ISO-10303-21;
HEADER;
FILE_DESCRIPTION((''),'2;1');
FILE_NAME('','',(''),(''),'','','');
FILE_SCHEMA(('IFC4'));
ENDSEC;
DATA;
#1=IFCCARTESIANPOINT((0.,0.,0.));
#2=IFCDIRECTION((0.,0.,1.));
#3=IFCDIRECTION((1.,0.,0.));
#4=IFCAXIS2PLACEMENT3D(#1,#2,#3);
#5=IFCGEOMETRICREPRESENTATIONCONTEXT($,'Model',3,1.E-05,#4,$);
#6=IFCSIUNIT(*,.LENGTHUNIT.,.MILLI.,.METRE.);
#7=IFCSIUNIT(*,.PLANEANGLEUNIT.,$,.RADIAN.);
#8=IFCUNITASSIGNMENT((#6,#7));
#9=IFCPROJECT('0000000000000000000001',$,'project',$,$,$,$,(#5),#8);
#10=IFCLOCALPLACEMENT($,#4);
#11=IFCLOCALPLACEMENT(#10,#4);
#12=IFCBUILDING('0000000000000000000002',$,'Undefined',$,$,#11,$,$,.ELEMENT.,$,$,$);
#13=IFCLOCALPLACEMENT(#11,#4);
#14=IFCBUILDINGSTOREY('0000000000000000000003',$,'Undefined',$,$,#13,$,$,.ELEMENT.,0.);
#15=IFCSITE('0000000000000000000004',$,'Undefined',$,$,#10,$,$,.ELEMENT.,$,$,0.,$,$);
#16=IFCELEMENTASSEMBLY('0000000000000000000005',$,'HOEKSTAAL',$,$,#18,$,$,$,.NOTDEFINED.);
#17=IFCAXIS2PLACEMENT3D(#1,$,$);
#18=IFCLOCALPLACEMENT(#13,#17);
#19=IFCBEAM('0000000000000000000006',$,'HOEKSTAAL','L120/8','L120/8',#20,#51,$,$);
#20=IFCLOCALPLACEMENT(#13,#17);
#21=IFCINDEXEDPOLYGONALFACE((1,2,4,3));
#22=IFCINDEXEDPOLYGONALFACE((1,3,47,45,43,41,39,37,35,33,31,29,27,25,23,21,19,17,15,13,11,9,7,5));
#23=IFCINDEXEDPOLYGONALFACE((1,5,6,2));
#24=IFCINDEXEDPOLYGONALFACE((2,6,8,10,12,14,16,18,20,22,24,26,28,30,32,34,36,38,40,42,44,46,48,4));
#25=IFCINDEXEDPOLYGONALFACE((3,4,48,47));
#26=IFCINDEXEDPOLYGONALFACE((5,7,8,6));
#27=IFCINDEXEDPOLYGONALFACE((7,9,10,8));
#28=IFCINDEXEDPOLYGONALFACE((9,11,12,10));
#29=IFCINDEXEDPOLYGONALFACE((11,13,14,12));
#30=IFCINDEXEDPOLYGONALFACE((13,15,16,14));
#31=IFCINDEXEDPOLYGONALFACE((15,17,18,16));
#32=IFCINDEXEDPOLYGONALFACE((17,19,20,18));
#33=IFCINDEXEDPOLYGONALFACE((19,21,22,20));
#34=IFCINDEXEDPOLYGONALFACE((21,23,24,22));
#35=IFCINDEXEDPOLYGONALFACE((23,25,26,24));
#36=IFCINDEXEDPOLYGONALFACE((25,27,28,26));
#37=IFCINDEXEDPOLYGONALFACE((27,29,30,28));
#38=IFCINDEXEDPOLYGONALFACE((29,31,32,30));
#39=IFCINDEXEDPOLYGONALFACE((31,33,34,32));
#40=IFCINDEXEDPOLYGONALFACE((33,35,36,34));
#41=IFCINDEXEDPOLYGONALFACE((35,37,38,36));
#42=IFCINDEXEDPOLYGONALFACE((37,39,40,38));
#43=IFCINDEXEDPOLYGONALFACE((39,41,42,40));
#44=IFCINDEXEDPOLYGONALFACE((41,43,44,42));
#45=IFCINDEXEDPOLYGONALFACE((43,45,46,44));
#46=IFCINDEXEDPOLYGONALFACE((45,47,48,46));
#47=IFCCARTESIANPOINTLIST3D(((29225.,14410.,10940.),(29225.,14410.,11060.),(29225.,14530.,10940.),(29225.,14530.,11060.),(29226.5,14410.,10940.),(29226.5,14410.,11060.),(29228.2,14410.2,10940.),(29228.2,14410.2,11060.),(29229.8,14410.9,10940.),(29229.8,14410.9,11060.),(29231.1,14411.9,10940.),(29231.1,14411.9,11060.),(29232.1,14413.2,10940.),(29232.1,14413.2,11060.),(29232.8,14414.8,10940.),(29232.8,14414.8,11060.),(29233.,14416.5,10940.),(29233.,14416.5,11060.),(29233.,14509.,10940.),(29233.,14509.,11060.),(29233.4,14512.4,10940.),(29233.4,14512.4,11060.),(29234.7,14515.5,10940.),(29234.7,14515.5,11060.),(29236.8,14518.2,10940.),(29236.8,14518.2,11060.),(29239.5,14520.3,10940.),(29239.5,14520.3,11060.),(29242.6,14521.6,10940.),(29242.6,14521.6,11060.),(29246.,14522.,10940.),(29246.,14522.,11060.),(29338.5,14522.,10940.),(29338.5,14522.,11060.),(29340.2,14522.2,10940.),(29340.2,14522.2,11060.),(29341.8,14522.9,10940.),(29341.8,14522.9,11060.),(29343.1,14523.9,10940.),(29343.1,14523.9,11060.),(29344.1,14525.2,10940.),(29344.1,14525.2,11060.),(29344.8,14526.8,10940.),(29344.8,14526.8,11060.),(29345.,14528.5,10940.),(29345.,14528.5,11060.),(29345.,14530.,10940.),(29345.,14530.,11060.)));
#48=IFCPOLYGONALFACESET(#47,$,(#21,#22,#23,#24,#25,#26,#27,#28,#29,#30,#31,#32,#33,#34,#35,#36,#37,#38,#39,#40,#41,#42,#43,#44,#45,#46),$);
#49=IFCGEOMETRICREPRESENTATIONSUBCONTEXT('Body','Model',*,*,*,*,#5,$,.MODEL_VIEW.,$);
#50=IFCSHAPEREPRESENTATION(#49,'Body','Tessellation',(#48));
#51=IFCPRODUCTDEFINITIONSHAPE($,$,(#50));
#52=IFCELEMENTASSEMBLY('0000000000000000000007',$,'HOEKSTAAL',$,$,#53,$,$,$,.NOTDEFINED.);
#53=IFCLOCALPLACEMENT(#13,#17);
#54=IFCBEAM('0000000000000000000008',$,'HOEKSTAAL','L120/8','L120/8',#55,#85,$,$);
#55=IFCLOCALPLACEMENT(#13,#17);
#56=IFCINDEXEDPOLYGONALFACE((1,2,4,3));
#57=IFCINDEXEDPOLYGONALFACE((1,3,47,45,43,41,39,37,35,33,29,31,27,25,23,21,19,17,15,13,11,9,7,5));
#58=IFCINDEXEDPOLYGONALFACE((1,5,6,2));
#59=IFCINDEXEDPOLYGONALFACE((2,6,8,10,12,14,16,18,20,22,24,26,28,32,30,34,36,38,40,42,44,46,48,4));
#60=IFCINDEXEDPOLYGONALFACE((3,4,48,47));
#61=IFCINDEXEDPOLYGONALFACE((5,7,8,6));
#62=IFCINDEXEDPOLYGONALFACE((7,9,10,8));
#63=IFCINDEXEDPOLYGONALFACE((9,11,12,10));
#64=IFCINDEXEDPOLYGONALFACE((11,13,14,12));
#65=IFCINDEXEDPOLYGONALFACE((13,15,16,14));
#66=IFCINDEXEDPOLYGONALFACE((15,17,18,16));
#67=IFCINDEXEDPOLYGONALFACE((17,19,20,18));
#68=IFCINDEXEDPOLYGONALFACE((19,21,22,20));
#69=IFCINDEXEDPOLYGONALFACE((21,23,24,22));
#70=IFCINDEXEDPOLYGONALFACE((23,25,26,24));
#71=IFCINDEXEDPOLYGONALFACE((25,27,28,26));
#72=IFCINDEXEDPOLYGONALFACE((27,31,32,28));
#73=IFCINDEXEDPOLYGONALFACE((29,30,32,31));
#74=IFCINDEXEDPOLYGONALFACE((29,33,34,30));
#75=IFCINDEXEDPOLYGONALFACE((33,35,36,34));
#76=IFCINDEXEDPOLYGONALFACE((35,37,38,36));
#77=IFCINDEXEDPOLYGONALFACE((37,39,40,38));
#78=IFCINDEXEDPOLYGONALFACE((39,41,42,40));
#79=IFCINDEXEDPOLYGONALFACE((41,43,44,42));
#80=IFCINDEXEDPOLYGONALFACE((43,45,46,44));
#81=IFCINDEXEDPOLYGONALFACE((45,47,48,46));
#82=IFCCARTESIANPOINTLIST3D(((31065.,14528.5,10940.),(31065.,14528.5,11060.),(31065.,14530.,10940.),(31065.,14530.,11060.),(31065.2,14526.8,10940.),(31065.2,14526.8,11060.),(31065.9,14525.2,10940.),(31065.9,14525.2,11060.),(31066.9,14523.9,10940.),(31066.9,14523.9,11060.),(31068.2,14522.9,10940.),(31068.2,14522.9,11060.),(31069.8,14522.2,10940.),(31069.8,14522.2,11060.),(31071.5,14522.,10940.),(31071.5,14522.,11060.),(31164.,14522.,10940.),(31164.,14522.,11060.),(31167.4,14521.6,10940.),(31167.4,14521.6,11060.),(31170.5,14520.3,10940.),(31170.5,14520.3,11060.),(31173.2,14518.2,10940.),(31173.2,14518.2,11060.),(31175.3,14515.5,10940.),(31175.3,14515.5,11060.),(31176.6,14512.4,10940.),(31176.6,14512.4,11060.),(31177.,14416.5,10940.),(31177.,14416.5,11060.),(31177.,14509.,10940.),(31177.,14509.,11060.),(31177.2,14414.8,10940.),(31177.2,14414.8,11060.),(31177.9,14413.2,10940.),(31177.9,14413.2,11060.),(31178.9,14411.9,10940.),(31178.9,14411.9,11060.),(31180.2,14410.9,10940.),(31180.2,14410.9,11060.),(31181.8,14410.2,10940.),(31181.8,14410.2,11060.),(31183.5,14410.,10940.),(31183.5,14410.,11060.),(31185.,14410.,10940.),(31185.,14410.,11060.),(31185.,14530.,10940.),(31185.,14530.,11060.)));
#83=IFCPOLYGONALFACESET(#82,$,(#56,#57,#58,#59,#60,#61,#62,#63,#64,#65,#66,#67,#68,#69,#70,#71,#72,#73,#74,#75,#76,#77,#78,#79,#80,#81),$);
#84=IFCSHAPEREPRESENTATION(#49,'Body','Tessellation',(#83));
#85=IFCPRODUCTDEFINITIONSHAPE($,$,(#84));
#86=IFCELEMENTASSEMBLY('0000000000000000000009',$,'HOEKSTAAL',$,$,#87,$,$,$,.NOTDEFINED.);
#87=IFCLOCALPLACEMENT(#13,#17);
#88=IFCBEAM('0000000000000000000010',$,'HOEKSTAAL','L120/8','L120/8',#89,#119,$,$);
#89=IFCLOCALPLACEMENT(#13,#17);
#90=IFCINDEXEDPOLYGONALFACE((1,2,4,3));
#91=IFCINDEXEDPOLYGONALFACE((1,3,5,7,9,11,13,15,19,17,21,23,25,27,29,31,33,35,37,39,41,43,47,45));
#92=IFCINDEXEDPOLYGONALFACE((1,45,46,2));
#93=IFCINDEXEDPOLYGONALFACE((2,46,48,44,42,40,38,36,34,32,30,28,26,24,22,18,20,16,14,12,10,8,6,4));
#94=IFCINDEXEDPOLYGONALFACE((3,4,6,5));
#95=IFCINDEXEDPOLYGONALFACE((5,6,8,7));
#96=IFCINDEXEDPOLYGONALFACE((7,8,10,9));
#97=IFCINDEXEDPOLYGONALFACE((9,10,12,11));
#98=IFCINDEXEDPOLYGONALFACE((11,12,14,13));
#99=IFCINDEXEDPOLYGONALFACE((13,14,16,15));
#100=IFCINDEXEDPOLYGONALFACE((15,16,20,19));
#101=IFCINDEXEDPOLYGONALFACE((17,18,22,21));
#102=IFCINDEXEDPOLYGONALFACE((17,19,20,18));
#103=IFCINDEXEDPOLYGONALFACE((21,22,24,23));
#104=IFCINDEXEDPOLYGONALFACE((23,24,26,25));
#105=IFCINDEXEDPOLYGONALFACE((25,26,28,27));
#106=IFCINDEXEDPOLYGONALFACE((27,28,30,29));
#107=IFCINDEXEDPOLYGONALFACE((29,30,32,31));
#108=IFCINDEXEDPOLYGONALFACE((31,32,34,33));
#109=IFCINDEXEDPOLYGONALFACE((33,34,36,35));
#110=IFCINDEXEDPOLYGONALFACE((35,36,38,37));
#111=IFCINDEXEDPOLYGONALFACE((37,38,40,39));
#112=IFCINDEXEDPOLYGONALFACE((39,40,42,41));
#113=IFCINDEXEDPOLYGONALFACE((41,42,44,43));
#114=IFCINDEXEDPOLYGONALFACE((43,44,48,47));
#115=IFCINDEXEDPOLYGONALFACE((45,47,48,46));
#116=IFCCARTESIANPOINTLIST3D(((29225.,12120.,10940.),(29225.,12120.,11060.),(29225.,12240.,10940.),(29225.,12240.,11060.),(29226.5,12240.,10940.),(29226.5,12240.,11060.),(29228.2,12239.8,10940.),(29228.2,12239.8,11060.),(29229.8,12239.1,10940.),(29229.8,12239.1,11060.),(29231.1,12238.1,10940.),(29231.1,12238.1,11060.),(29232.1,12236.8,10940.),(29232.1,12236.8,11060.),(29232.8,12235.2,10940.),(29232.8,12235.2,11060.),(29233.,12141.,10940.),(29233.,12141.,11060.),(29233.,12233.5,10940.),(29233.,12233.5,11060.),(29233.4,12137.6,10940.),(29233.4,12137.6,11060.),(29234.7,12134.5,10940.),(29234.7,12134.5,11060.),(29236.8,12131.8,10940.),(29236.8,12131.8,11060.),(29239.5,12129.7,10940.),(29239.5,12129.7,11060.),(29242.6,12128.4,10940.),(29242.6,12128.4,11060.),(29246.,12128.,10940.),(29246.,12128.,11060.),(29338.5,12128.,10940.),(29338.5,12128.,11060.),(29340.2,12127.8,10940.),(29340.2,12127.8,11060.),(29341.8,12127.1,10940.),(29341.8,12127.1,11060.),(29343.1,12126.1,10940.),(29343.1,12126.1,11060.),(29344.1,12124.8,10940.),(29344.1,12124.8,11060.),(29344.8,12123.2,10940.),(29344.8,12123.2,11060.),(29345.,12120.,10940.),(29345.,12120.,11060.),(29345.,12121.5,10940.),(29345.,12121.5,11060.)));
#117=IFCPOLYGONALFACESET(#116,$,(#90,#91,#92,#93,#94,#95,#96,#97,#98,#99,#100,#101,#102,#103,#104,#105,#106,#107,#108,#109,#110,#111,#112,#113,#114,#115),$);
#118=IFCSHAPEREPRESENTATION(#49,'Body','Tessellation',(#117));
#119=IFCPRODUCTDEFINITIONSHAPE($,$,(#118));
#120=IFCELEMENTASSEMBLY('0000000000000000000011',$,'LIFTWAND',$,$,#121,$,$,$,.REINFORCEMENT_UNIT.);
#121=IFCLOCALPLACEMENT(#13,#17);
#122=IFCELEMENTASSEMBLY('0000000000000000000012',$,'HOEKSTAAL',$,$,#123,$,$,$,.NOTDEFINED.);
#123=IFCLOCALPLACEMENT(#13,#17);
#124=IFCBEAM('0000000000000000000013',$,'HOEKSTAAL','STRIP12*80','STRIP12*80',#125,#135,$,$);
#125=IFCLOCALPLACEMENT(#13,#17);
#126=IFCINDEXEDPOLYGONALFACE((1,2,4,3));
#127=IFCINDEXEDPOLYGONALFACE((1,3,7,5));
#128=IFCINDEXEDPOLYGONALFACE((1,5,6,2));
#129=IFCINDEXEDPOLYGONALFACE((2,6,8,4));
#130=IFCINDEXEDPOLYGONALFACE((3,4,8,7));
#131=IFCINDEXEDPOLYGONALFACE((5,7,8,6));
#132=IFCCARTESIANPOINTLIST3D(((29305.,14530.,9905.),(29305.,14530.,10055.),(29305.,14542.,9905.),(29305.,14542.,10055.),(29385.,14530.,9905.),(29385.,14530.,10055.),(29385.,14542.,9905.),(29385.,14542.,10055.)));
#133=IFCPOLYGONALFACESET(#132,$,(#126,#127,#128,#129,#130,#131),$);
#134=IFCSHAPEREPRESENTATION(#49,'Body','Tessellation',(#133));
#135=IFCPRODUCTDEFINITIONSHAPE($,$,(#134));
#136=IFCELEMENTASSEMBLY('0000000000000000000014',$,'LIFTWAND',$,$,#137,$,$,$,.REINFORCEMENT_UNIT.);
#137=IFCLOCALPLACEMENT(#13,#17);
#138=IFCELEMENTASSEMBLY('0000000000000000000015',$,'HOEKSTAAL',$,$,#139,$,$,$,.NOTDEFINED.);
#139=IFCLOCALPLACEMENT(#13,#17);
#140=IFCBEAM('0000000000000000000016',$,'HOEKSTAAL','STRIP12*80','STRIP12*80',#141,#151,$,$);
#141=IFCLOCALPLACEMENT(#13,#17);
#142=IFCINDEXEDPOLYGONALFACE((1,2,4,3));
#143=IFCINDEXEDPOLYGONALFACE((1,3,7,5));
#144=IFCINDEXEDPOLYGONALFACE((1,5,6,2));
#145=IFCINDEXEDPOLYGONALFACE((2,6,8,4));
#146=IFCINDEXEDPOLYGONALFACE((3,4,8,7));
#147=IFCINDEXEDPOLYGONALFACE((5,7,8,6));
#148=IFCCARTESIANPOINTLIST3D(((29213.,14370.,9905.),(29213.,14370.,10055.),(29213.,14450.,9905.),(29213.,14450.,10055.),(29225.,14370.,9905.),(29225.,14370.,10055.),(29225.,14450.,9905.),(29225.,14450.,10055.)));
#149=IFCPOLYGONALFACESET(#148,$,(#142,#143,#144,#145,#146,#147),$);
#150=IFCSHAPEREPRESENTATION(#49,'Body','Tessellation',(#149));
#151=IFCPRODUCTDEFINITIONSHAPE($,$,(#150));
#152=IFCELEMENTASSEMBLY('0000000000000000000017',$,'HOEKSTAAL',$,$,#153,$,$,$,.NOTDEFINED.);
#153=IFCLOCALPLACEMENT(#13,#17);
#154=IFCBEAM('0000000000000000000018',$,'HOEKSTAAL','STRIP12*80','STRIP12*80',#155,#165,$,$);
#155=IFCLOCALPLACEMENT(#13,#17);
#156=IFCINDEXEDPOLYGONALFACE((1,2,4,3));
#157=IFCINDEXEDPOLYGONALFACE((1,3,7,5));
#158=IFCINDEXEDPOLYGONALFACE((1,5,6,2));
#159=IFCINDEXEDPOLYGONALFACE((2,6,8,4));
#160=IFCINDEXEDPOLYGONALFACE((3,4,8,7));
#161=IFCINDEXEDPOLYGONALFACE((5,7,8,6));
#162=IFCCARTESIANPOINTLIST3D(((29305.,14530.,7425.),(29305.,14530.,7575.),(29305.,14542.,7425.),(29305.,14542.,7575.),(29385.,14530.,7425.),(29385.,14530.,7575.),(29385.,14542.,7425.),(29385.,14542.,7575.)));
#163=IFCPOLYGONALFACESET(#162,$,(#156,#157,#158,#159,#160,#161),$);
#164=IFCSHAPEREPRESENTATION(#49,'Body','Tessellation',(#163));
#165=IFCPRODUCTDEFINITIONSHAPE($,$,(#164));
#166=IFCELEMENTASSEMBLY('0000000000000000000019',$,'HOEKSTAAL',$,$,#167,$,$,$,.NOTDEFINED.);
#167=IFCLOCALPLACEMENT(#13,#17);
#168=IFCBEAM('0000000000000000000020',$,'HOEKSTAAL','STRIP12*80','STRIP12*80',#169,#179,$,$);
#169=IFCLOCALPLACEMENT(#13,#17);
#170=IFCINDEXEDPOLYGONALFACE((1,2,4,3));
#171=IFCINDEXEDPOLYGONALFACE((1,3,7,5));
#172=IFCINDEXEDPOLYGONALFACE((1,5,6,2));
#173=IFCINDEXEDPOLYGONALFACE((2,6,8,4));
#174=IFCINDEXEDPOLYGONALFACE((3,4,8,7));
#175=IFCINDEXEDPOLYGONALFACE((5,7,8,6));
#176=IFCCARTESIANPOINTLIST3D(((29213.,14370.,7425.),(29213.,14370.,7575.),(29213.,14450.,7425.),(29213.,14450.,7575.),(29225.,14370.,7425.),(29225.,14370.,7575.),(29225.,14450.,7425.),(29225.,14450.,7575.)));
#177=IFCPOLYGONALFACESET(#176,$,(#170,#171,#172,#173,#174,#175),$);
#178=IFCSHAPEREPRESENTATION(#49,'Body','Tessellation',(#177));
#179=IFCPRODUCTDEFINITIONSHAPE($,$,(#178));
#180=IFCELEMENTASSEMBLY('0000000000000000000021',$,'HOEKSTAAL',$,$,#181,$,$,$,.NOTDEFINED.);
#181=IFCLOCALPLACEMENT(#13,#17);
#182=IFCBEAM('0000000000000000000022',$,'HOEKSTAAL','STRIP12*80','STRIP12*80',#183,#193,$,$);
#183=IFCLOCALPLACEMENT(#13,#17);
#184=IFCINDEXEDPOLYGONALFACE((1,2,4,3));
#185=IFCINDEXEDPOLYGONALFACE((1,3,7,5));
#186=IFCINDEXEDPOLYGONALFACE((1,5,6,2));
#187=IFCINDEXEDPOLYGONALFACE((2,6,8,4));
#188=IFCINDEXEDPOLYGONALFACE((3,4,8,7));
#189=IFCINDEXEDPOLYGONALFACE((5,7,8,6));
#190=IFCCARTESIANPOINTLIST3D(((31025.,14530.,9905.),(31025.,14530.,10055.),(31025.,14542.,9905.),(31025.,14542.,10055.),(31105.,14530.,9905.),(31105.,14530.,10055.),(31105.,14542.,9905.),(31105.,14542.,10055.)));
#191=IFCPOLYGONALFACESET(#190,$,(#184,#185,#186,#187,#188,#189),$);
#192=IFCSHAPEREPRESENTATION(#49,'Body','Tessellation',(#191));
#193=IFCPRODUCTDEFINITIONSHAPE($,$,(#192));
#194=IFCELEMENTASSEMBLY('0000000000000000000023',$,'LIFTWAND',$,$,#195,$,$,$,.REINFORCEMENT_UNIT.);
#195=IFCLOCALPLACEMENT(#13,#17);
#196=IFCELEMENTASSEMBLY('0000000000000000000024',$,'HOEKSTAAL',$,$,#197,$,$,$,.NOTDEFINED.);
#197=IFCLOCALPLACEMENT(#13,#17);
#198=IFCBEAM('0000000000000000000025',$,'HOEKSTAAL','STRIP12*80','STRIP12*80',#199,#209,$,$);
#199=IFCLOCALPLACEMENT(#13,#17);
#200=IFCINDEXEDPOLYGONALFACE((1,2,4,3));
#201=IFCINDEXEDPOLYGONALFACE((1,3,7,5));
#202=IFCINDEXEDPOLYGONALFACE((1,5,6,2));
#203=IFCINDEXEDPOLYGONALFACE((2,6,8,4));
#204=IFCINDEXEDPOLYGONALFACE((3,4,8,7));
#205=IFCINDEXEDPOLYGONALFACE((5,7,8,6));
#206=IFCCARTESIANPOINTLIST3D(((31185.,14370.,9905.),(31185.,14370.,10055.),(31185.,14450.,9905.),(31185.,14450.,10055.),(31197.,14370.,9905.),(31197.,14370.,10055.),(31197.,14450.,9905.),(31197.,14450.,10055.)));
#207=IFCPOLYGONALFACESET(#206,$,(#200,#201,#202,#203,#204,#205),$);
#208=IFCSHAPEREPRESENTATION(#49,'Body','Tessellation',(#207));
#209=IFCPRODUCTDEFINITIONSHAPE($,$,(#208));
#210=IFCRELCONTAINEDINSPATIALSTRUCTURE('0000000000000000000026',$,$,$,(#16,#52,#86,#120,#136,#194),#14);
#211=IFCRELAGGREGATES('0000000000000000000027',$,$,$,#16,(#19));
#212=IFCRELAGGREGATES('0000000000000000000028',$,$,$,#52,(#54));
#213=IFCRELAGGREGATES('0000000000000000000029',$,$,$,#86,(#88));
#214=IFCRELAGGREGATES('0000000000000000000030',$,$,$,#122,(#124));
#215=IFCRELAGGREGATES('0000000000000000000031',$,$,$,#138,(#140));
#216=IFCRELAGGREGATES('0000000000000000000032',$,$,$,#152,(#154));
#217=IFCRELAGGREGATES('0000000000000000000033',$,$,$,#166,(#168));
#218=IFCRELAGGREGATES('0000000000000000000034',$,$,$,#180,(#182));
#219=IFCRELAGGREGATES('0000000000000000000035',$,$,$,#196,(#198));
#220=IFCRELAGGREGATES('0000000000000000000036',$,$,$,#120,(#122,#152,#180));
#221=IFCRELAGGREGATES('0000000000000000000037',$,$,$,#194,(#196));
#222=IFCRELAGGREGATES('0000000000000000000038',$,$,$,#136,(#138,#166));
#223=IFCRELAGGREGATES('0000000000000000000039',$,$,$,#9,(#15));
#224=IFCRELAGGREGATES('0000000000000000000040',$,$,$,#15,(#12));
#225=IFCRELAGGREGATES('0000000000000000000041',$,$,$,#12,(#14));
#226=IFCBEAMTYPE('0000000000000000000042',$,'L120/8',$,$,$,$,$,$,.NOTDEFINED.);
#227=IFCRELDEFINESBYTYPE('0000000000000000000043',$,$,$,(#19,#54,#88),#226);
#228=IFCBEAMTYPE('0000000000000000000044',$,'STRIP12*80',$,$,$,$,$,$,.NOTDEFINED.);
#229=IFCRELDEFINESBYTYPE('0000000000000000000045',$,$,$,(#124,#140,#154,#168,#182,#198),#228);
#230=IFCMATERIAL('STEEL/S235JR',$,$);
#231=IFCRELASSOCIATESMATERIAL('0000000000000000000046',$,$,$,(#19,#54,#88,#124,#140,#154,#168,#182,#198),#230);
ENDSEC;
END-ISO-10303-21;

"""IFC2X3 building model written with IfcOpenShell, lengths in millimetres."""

from ifc_helpers import new_model, si_unit, frame, origin_with_axes, origin_2d_with_axis, place, context, subcontext, project, spatial, rectangle, l_section, extrude, material, type_object, element, aggregate, save


model = new_model("IFC2X3")

# Units and contexts
model_context = context("Model", 3, precision=1e-05, world=origin_with_axes())
body_context = subcontext(model_context, "Body", "Model", "MODEL_VIEW")
ifc_project = project(units=[si_unit("LENGTHUNIT", "METRE", prefix="MILLI"), si_unit("PLANEANGLEUNIT", "RADIAN")], contexts=[model_context])

# Site, building, storey
site_placement = place(None, origin_with_axes())
site = spatial("IfcSite", under=ifc_project, at=site_placement, Name="Undefined", CompositionType="ELEMENT", RefElevation=0.0)
building_placement = place(site_placement, origin_with_axes())
building = spatial("IfcBuilding", under=site, at=building_placement, Name="Undefined", CompositionType="ELEMENT")
storey_placement = place(building_placement, origin_with_axes())
storey = spatial("IfcBuildingStorey", under=building, at=storey_placement, Name="Undefined", CompositionType="ELEMENT", Elevation=0.0)

# Element assemblies, beams
ifc_material_1 = material(Name="STEEL/S235JR")
beam_type_1 = type_object("IfcBeamType", Name="L120/8", PredefinedType="NOTDEFINED")
assembly_1_placement = place(storey_placement, origin_with_axes())
assembly_1 = element("IfcElementAssembly", 1, at=assembly_1_placement, inside=storey, Name="HOEKSTAAL", PredefinedType="NOTDEFINED")
beam_1_placement = place(assembly_1_placement, frame((29285.0, 14470.0, 11060.0), z_axis=(1.0, 0.0, 0.0), x_axis=(0.0, 0.0, -1.0)))
beam_1 = element("IfcBeam", 2, at=beam_1_placement, type_object=beam_type_1, material=ifc_material_1, Name="HOEKSTAAL", Description="L120/8", ObjectType="L120/8", context=body_context, shape_type="SweptSolid", body=[
    extrude(l_section(Depth=120.0, Width=120.0, Thickness=8.0, FilletRadius=13.0, EdgeRadius=6.5, at=origin_2d_with_axis()), frame((120.0, 0.0, 0.0), z_axis=(-1.0, 0.0, 0.0), x_axis=(0.0, -1.0, 0.0)), (0.0, 0.0, 1.0), 120.0),
])
aggregate(assembly_1, [beam_1])
assembly_2_placement = place(storey_placement, origin_with_axes())
assembly_2 = element("IfcElementAssembly", 3, at=assembly_2_placement, inside=storey, Name="HOEKSTAAL", PredefinedType="NOTDEFINED")
beam_2_placement = place(assembly_2_placement, frame((31125.0, 14470.0, 10940.0), z_axis=(-1.0, 0.0, 0.0), x_axis=(0.0, 0.0, 1.0)))
beam_2 = element("IfcBeam", 4, at=beam_2_placement, type_object=beam_type_1, material=ifc_material_1, Name="HOEKSTAAL", Description="L120/8", ObjectType="L120/8", context=body_context, shape_type="SweptSolid", body=[
    extrude(l_section(Depth=120.0, Width=120.0, Thickness=8.0, FilletRadius=13.0, EdgeRadius=6.5, at=origin_2d_with_axis()), frame((120.0, 0.0, 0.0), z_axis=(-1.0, 0.0, 0.0), x_axis=(0.0, -1.0, 0.0)), (0.0, 0.0, 1.0), 120.0),
])
aggregate(assembly_2, [beam_2])
assembly_3_placement = place(storey_placement, origin_with_axes())
assembly_3 = element("IfcElementAssembly", 5, at=assembly_3_placement, inside=storey, Name="HOEKSTAAL", PredefinedType="NOTDEFINED")
beam_3_placement = place(assembly_3_placement, frame((29285.0, 12180.0, 10940.0), z_axis=(1.0, 0.0, 0.0), x_axis=(0.0, 0.0, 1.0)))
beam_3 = element("IfcBeam", 6, at=beam_3_placement, type_object=beam_type_1, material=ifc_material_1, Name="HOEKSTAAL", Description="L120/8", ObjectType="L120/8", context=body_context, shape_type="SweptSolid", body=[
    extrude(l_section(Depth=120.0, Width=120.0, Thickness=8.0, FilletRadius=13.0, EdgeRadius=6.5, at=origin_2d_with_axis()), frame((120.0, 0.0, 0.0), z_axis=(-1.0, 0.0, 0.0), x_axis=(0.0, -1.0, 0.0)), (0.0, 0.0, 1.0), 120.0),
])
aggregate(assembly_3, [beam_3])

# Element assemblies, beams
assembly_4_placement = place(storey_placement, origin_with_axes())
assembly_4 = element("IfcElementAssembly", 7, at=assembly_4_placement, inside=storey, Name="LIFTWAND", PredefinedType="REINFORCEMENT_UNIT")
assembly_5_placement = place(assembly_4_placement, origin_with_axes())
assembly_5 = element("IfcElementAssembly", 8, at=assembly_5_placement, Name="HOEKSTAAL", PredefinedType="NOTDEFINED")
beam_type_2 = type_object("IfcBeamType", Name="STRIP12*80", PredefinedType="NOTDEFINED")
beam_4_placement = place(assembly_5_placement, frame((29345.0, 14536.0, 10055.0), z_axis=(1.0, 0.0, 0.0), x_axis=(0.0, 0.0, -1.0)))
beam_4 = element("IfcBeam", 9, at=beam_4_placement, type_object=beam_type_2, material=ifc_material_1, Name="HOEKSTAAL", Description="STRIP12*80", ObjectType="STRIP12*80", context=body_context, shape_type="SweptSolid", body=[
    extrude(rectangle(XDim=12.0, YDim=80.0, at=origin_2d_with_axis()), frame((150.0, 0.0, 0.0), z_axis=(-1.0, 0.0, 0.0), x_axis=(0.0, -1.0, 0.0)), (0.0, 0.0, 1.0), 150.0),
])
aggregate(assembly_5, [beam_4])
assembly_6_placement = place(storey_placement, origin_with_axes())
assembly_6 = element("IfcElementAssembly", 10, at=assembly_6_placement, inside=storey, Name="LIFTWAND", PredefinedType="REINFORCEMENT_UNIT")
assembly_7_placement = place(assembly_6_placement, origin_with_axes())
assembly_7 = element("IfcElementAssembly", 11, at=assembly_7_placement, Name="HOEKSTAAL", PredefinedType="NOTDEFINED")
beam_5_placement = place(assembly_7_placement, frame((29219.0, 14410.0, 10055.0), z_axis=(0.0, 1.0, 0.0), x_axis=(0.0, 0.0, -1.0)))
beam_5 = element("IfcBeam", 12, at=beam_5_placement, type_object=beam_type_2, material=ifc_material_1, Name="HOEKSTAAL", Description="STRIP12*80", ObjectType="STRIP12*80", context=body_context, shape_type="SweptSolid", body=[
    extrude(rectangle(XDim=12.0, YDim=80.0, at=origin_2d_with_axis()), frame((150.0, 0.0, 0.0), z_axis=(-1.0, 0.0, 0.0), x_axis=(0.0, -1.0, 0.0)), (0.0, 0.0, 1.0), 150.0),
])
aggregate(assembly_7, [beam_5])

# Element assemblies, beams
assembly_8_placement = place(assembly_4_placement, origin_with_axes())
assembly_8 = element("IfcElementAssembly", 13, at=assembly_8_placement, Name="HOEKSTAAL", PredefinedType="NOTDEFINED")
beam_6_placement = place(assembly_8_placement, frame((29345.0, 14536.0, 7575.0), z_axis=(1.0, 0.0, 0.0), x_axis=(0.0, 0.0, -1.0)))
beam_6 = element("IfcBeam", 14, at=beam_6_placement, type_object=beam_type_2, material=ifc_material_1, Name="HOEKSTAAL", Description="STRIP12*80", ObjectType="STRIP12*80", context=body_context, shape_type="SweptSolid", body=[
    extrude(rectangle(XDim=12.0, YDim=80.0, at=origin_2d_with_axis()), frame((150.0, 0.0, 0.0), z_axis=(-1.0, 0.0, 0.0), x_axis=(0.0, -1.0, 0.0)), (0.0, 0.0, 1.0), 150.0),
])
aggregate(assembly_8, [beam_6])
assembly_9_placement = place(assembly_6_placement, origin_with_axes())
assembly_9 = element("IfcElementAssembly", 15, at=assembly_9_placement, Name="HOEKSTAAL", PredefinedType="NOTDEFINED")
beam_7_placement = place(assembly_9_placement, frame((29219.0, 14410.0, 7575.0), z_axis=(0.0, 1.0, 0.0), x_axis=(0.0, 0.0, -1.0)))
beam_7 = element("IfcBeam", 16, at=beam_7_placement, type_object=beam_type_2, material=ifc_material_1, Name="HOEKSTAAL", Description="STRIP12*80", ObjectType="STRIP12*80", context=body_context, shape_type="SweptSolid", body=[
    extrude(rectangle(XDim=12.0, YDim=80.0, at=origin_2d_with_axis()), frame((150.0, 0.0, 0.0), z_axis=(-1.0, 0.0, 0.0), x_axis=(0.0, -1.0, 0.0)), (0.0, 0.0, 1.0), 150.0),
])
aggregate(assembly_9, [beam_7])
assembly_10_placement = place(assembly_4_placement, origin_with_axes())
assembly_10 = element("IfcElementAssembly", 17, at=assembly_10_placement, Name="HOEKSTAAL", PredefinedType="NOTDEFINED")
beam_8_placement = place(assembly_10_placement, frame((31065.0, 14536.0, 10055.0), z_axis=(-1.0, 0.0, 0.0), x_axis=(0.0, 0.0, -1.0)))
beam_8 = element("IfcBeam", 18, at=beam_8_placement, type_object=beam_type_2, material=ifc_material_1, Name="HOEKSTAAL", Description="STRIP12*80", ObjectType="STRIP12*80", context=body_context, shape_type="SweptSolid", body=[
    extrude(rectangle(XDim=12.0, YDim=80.0, at=origin_2d_with_axis()), frame((150.0, 0.0, 0.0), z_axis=(-1.0, 0.0, 0.0), x_axis=(0.0, -1.0, 0.0)), (0.0, 0.0, 1.0), 150.0),
])
aggregate(assembly_10, [beam_8])

# Element assemblies, beam
assembly_11_placement = place(storey_placement, origin_with_axes())
assembly_11 = element("IfcElementAssembly", 19, at=assembly_11_placement, inside=storey, Name="LIFTWAND", PredefinedType="REINFORCEMENT_UNIT")
assembly_12_placement = place(assembly_11_placement, origin_with_axes())
assembly_12 = element("IfcElementAssembly", 20, at=assembly_12_placement, Name="HOEKSTAAL", PredefinedType="NOTDEFINED")
beam_9_placement = place(assembly_12_placement, frame((31191.0, 14410.0, 10055.0), z_axis=(0.0, 1.0, 0.0), x_axis=(0.0, 0.0, -1.0)))
beam_9 = element("IfcBeam", 21, at=beam_9_placement, type_object=beam_type_2, material=ifc_material_1, Name="HOEKSTAAL", Description="STRIP12*80", ObjectType="STRIP12*80", context=body_context, shape_type="SweptSolid", body=[
    extrude(rectangle(XDim=12.0, YDim=80.0, at=origin_2d_with_axis()), frame((150.0, 0.0, 0.0), z_axis=(-1.0, 0.0, 0.0), x_axis=(0.0, -1.0, 0.0)), (0.0, 0.0, 1.0), 150.0),
])
aggregate(assembly_12, [beam_9])

aggregate(assembly_4, [assembly_5, assembly_8, assembly_10])

aggregate(assembly_11, [assembly_12])

aggregate(assembly_6, [assembly_7, assembly_9])

save(model, "model.ifc")
